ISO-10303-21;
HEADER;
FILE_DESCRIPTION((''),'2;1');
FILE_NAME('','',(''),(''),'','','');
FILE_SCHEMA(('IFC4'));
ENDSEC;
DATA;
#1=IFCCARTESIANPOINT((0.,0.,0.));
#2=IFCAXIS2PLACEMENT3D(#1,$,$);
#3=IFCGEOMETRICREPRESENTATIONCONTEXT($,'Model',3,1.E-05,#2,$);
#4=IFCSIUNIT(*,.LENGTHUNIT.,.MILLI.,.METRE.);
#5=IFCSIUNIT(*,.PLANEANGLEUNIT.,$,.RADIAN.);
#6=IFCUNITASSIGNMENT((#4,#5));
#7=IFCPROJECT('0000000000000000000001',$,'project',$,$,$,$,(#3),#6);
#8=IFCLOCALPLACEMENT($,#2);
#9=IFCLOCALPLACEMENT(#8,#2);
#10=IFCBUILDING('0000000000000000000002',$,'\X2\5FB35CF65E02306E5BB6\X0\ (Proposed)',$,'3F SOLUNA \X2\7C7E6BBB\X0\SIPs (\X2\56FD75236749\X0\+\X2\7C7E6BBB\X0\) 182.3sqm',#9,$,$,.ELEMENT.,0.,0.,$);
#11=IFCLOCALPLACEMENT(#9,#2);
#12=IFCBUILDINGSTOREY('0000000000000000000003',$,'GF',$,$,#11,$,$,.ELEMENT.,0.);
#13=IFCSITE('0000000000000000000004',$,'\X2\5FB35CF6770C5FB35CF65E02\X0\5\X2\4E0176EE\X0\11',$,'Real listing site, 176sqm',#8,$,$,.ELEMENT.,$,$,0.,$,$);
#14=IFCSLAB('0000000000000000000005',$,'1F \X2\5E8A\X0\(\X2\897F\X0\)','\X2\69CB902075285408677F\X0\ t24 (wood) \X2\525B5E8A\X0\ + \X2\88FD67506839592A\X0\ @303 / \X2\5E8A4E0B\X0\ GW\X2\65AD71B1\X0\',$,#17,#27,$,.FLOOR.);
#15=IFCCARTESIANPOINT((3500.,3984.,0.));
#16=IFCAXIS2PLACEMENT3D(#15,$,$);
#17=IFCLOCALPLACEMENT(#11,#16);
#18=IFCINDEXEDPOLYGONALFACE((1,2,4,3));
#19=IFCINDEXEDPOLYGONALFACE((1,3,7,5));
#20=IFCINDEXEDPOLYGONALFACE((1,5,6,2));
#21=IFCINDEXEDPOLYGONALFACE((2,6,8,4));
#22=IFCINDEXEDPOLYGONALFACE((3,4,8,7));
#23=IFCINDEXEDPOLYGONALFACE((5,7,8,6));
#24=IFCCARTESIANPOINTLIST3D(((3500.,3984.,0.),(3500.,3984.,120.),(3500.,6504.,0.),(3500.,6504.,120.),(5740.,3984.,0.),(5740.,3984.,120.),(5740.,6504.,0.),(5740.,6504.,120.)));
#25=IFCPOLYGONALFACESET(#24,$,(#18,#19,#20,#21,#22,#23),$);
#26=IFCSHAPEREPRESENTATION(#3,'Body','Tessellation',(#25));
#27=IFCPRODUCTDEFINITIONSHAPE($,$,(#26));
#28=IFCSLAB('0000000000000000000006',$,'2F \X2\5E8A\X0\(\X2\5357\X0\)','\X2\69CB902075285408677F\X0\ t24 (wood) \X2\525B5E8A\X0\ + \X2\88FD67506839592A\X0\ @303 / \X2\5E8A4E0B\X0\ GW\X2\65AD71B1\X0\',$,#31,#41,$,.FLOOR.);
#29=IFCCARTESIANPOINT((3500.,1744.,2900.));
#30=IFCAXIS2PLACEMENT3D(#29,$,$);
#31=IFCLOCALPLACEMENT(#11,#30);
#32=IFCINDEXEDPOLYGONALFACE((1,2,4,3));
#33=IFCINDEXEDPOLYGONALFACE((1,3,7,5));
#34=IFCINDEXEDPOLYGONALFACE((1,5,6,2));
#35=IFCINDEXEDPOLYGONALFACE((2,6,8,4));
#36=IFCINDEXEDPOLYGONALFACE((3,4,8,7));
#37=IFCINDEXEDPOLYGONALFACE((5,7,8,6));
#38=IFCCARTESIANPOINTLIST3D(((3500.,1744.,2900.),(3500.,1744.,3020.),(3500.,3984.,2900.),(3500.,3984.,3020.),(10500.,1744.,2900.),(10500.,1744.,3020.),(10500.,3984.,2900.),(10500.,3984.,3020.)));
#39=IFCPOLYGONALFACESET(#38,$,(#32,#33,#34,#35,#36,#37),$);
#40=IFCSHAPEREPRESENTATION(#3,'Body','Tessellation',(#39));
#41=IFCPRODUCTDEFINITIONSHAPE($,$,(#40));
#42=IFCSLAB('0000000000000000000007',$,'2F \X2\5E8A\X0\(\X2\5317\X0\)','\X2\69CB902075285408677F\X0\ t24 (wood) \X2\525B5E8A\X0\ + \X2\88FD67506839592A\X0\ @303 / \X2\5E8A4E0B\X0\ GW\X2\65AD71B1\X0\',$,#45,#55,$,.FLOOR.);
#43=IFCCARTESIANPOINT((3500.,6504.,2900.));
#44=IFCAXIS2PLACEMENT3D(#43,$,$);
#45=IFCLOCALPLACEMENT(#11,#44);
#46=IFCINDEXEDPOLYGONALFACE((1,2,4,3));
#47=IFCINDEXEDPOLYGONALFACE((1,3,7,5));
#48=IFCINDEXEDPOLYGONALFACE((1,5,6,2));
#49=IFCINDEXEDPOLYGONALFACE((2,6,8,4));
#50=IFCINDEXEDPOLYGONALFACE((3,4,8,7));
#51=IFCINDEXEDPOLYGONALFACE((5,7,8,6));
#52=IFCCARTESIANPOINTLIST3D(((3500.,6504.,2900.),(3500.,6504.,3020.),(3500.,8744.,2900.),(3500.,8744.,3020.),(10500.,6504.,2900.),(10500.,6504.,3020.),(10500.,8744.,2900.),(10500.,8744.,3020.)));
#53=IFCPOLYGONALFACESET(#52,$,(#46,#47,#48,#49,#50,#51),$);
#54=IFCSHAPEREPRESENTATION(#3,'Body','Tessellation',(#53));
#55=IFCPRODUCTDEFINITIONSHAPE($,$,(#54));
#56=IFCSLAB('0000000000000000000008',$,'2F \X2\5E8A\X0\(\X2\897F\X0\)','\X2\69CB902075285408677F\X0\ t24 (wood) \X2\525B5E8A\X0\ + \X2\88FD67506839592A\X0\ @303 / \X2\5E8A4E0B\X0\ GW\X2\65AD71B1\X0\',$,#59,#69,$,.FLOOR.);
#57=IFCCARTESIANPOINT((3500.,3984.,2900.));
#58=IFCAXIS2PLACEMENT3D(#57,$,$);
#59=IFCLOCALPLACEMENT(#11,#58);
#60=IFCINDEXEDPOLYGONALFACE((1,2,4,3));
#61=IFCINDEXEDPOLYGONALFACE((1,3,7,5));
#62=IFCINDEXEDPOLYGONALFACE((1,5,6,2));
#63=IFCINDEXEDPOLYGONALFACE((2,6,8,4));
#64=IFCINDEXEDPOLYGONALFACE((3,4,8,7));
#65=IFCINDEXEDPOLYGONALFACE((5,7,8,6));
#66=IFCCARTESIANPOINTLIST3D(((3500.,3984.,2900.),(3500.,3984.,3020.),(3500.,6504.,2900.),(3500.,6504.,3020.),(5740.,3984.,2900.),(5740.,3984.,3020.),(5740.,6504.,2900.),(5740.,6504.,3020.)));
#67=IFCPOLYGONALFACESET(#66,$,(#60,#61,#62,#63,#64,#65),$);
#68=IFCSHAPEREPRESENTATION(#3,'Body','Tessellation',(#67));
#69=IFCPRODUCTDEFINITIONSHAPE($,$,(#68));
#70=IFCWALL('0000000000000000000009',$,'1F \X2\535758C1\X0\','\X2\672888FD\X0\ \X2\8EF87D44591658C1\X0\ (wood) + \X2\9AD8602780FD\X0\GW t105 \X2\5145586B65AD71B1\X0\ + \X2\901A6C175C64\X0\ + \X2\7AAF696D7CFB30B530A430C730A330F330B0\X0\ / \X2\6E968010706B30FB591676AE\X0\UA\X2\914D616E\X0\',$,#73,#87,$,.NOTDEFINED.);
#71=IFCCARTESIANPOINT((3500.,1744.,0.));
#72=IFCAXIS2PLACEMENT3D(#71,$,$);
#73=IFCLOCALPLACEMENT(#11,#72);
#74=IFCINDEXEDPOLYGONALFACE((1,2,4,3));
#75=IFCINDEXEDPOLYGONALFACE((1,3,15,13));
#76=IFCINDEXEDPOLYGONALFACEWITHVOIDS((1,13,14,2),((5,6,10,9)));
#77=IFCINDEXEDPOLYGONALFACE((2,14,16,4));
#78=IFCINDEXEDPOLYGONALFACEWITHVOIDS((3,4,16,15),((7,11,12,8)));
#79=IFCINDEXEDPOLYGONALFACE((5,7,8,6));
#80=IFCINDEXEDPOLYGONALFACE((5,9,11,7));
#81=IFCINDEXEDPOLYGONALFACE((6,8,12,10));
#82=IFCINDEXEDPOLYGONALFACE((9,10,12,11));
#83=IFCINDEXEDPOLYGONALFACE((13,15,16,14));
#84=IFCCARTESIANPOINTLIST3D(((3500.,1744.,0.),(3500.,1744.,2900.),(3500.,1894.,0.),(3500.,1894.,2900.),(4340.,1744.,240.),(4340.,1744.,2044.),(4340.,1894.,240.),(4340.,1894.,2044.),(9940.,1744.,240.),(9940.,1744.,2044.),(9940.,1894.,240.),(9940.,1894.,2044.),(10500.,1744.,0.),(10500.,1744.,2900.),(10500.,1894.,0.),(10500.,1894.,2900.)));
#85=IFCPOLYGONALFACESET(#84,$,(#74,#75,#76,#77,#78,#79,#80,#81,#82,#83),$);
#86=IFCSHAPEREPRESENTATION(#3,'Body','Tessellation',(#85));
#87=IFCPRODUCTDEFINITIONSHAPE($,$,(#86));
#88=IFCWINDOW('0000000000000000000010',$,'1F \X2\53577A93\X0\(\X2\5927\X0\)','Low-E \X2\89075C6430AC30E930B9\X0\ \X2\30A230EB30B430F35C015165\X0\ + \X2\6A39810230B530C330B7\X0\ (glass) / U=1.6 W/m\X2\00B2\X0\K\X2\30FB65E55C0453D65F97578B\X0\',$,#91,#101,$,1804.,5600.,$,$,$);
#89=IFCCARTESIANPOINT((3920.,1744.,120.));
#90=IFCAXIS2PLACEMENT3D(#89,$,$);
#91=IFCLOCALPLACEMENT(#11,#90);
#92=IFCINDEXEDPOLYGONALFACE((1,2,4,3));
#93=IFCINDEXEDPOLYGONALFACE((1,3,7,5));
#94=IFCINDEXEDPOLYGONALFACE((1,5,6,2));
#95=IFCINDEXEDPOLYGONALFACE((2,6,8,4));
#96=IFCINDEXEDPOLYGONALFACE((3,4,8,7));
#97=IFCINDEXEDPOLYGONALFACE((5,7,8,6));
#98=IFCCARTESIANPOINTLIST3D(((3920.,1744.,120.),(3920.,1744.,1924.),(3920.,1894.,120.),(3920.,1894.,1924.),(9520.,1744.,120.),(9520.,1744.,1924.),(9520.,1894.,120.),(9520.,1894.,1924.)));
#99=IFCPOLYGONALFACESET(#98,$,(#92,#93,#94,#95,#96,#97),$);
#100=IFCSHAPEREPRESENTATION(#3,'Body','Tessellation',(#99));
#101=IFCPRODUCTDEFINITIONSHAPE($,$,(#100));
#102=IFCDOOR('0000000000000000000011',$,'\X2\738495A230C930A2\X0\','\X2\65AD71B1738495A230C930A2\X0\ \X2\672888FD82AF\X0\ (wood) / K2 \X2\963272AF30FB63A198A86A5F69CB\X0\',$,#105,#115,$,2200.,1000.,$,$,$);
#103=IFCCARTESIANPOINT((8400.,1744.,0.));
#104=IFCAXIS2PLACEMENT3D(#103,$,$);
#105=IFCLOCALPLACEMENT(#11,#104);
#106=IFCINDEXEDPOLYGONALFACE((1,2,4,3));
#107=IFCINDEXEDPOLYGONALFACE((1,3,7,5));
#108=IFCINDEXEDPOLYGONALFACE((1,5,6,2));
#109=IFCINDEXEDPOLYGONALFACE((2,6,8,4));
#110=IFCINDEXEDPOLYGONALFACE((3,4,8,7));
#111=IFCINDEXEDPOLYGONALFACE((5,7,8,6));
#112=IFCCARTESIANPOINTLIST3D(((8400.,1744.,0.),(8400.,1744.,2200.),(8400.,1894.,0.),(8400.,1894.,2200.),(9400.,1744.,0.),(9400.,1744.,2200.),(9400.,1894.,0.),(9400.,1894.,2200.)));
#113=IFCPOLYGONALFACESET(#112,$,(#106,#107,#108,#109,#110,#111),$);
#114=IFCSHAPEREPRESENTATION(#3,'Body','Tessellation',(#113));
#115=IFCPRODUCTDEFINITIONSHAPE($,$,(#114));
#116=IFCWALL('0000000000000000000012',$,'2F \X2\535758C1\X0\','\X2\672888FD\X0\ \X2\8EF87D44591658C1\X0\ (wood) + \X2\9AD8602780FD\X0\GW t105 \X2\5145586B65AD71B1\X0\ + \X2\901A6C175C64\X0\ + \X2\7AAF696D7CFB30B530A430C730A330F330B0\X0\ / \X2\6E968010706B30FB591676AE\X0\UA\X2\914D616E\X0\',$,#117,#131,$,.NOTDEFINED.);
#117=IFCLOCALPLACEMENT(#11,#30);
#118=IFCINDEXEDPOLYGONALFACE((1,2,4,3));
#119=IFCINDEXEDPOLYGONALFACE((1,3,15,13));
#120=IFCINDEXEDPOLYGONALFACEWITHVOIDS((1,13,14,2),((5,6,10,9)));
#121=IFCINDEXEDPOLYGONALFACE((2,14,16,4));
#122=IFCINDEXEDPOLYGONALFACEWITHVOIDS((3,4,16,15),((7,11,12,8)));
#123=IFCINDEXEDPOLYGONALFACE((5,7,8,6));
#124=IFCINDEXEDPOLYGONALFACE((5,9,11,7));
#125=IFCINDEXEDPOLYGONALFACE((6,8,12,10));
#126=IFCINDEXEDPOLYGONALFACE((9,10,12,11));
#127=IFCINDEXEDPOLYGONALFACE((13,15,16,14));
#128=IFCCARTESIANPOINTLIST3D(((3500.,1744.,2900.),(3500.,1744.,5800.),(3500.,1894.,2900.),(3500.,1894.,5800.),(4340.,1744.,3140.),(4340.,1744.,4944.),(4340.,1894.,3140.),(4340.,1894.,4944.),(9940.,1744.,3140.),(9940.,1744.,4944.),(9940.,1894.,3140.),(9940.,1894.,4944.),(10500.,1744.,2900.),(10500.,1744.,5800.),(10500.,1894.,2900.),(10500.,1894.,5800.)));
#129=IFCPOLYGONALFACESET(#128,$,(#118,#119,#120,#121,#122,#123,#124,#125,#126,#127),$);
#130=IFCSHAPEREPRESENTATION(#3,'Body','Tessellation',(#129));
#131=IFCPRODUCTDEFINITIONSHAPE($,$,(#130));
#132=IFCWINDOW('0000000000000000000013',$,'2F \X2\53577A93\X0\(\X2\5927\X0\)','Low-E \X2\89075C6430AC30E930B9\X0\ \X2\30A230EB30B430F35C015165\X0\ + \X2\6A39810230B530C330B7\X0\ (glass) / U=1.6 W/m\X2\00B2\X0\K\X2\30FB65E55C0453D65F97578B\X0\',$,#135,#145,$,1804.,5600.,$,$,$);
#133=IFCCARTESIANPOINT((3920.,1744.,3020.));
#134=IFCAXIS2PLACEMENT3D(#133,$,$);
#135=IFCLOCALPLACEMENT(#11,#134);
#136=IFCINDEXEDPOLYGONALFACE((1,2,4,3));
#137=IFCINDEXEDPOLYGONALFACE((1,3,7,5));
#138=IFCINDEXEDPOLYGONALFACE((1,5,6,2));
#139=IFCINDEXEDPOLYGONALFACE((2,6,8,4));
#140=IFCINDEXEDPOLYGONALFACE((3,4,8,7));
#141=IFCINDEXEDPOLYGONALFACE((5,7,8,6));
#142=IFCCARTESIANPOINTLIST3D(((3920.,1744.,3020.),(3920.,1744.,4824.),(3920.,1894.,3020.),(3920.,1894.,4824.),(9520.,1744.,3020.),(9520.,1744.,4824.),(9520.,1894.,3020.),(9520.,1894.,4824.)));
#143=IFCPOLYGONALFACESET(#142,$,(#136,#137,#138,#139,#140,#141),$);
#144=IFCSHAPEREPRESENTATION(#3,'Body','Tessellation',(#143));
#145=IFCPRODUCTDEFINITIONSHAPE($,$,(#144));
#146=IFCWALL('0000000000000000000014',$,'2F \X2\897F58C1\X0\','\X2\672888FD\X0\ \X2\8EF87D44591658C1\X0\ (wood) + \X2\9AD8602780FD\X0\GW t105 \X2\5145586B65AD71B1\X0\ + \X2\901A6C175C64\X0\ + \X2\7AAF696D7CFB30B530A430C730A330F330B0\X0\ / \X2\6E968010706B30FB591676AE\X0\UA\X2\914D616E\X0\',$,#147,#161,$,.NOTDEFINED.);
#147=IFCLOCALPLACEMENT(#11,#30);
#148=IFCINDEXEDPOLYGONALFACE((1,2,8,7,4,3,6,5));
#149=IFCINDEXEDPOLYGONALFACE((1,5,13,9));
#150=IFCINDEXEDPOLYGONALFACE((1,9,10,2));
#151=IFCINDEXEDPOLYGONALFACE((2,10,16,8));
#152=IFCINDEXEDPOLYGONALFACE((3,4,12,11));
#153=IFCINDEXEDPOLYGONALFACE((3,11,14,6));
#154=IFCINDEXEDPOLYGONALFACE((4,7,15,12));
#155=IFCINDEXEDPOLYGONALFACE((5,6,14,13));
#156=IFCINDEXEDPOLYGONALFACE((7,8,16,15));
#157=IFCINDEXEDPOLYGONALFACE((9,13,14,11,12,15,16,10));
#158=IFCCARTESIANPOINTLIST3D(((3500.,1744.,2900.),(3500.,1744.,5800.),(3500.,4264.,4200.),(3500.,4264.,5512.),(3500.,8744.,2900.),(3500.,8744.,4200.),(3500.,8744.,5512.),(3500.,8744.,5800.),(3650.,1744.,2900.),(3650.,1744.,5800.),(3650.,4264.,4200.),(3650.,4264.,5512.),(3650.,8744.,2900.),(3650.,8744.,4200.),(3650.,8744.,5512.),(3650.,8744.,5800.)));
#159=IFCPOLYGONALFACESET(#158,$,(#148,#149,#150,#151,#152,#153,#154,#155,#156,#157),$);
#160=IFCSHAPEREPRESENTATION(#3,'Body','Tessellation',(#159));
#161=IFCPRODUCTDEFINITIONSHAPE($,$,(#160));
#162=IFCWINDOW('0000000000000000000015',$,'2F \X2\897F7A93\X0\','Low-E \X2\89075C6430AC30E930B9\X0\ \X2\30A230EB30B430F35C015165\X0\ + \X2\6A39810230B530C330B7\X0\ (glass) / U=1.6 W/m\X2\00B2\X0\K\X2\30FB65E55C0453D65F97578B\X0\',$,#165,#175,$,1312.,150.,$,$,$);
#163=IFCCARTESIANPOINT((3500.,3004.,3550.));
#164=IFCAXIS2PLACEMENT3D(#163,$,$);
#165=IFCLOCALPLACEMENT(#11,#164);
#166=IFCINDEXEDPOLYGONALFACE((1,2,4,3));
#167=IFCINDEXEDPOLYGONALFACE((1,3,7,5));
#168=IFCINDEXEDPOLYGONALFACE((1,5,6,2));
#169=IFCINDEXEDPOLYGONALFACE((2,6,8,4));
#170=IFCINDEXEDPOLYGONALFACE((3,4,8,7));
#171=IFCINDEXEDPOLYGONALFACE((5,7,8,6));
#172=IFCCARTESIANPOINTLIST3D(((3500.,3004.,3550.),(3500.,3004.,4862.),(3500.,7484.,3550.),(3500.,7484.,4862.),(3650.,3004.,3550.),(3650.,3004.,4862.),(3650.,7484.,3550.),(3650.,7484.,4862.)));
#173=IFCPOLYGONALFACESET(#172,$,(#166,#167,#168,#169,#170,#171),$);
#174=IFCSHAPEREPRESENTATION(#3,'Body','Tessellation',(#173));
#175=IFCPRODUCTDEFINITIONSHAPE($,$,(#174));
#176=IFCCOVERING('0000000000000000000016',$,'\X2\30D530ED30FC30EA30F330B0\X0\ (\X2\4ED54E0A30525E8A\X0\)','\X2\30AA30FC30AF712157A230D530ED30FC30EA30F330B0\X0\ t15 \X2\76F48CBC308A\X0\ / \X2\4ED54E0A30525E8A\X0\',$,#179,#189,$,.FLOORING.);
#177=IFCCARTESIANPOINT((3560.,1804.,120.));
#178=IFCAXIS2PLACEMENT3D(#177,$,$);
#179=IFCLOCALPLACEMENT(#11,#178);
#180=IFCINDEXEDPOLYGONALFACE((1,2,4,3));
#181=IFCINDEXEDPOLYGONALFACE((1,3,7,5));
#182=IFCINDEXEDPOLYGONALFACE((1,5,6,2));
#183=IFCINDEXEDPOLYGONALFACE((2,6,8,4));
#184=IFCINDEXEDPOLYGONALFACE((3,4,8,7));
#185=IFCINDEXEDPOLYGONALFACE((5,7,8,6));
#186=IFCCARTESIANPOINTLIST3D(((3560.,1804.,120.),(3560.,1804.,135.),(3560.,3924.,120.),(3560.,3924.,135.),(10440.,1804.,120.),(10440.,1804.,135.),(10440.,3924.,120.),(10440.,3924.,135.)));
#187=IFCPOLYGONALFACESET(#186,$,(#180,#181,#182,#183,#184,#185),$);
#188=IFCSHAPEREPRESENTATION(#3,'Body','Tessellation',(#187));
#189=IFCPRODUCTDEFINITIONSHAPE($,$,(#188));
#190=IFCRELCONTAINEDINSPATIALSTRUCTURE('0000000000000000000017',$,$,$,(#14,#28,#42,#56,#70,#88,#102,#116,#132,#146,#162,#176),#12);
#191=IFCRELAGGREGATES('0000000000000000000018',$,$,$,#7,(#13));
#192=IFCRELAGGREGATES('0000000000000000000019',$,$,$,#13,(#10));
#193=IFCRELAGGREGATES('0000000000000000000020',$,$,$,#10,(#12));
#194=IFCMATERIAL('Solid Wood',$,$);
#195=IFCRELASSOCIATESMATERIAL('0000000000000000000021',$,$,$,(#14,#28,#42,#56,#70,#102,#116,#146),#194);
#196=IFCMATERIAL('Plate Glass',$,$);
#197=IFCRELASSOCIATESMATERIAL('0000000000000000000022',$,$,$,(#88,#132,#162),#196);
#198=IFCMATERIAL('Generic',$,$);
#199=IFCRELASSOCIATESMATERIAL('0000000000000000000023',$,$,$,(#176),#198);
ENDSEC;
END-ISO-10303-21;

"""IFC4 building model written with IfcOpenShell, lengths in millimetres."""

from ifc_helpers import new_model, si_unit, frame, frame_2d, origin, place, context, project, spatial, rectangle, extrude, material, element, fill, save


model = new_model("IFC4")

# Units and contexts
model_context = context("Model", 3, precision=1e-05, world=origin())
ifc_project = project(units=[si_unit("LENGTHUNIT", "METRE", prefix="MILLI"), si_unit("PLANEANGLEUNIT", "RADIAN")], contexts=[model_context])

# Site, building, storey
site_placement = place(None, origin())
site = spatial("IfcSite", under=ifc_project, at=site_placement, Name="徳島県徳島市5丁目11", ObjectType="Real listing site, 176sqm", CompositionType="ELEMENT", RefElevation=0.0)
building_placement = place(site_placement, origin())
building = spatial("IfcBuilding", under=site, at=building_placement, Name="徳島市の家 (Proposed)", ObjectType="3F SOLUNA 籾殻SIPs (国産杉+籾殻) 182.3sqm", CompositionType="ELEMENT", ElevationOfRefHeight=0.0, ElevationOfTerrain=0.0)
storey_placement = place(building_placement, origin())
storey = spatial("IfcBuildingStorey", under=building, at=storey_placement, Name="GF", CompositionType="ELEMENT", Elevation=0.0)

# Slabs
ifc_material_1 = material(Name="Solid Wood")
slab_1_placement = place(storey_placement, frame((3500.0, 3984.0, 0.0)))
element("IfcSlab", 1, at=slab_1_placement, inside=storey, material=ifc_material_1, Name="1F 床(西)", Description="構造用合板 t24 (wood) 剛床 + 製材根太 @303 / 床下 GW断熱", PredefinedType="FLOOR", context=model_context, shape_type="SweptSolid", body=[
    extrude(rectangle(XDim=2240.0, YDim=2520.0, at=frame_2d((1120.0, 1260.0))), frame((3500.0, 3984.0, 0.0)), (0.0, 0.0, 1.0), 120.0),
])
slab_2_placement = place(storey_placement, frame((3500.0, 1744.0, 2900.0)))
element("IfcSlab", 2, at=slab_2_placement, inside=storey, material=ifc_material_1, Name="2F 床(南)", Description="構造用合板 t24 (wood) 剛床 + 製材根太 @303 / 床下 GW断熱", PredefinedType="FLOOR", context=model_context, shape_type="SweptSolid", body=[
    extrude(rectangle(XDim=7000.0, YDim=2240.0, at=frame_2d((3500.0, 1120.0))), frame((3500.0, 1744.0, 2900.0)), (0.0, 0.0, 1.0), 120.0),
])
slab_3_placement = place(storey_placement, frame((3500.0, 6504.0, 2900.0)))
element("IfcSlab", 3, at=slab_3_placement, inside=storey, material=ifc_material_1, Name="2F 床(北)", Description="構造用合板 t24 (wood) 剛床 + 製材根太 @303 / 床下 GW断熱", PredefinedType="FLOOR", context=model_context, shape_type="SweptSolid", body=[
    extrude(rectangle(XDim=7000.0, YDim=2240.0, at=frame_2d((3500.0, 1120.0))), frame((3500.0, 6504.0, 2900.0)), (0.0, 0.0, 1.0), 120.0),
])
slab_4_placement = place(storey_placement, frame((3500.0, 3984.0, 2900.0)))
element("IfcSlab", 4, at=slab_4_placement, inside=storey, material=ifc_material_1, Name="2F 床(西)", Description="構造用合板 t24 (wood) 剛床 + 製材根太 @303 / 床下 GW断熱", PredefinedType="FLOOR", context=model_context, shape_type="SweptSolid", body=[
    extrude(rectangle(XDim=2240.0, YDim=2520.0, at=frame_2d((1120.0, 1260.0))), frame((3500.0, 3984.0, 2900.0)), (0.0, 0.0, 1.0), 120.0),
])

# Wall, openings, window, door
wall_1_placement = place(storey_placement, frame((3500.0, 1744.0, 0.0)))
wall_1 = element("IfcWall", 5, at=wall_1_placement, inside=storey, material=ifc_material_1, Name="1F 南壁", Description="木製 軸組外壁 (wood) + 高性能GW t105 充填断熱 + 通気層 + 窯業系サイディング / 準耐火・外皮UA配慮", PredefinedType="NOTDEFINED", context=model_context, shape_type="SweptSolid", body=[
    extrude(rectangle(XDim=7000.0, YDim=150.0, at=frame_2d((3500.0, 75.0))), frame((3500.0, 1744.0, 0.0)), (0.0, 0.0, 1.0), 2900.0),
])
opening_1_placement = place(storey_placement, frame((3920.0, 1744.0, 120.0)))
opening_1 = element("IfcOpeningElement", 6, at=opening_1_placement, cuts=wall_1, PredefinedType="NOTDEFINED", context=model_context, shape_type="SweptSolid", body=[
    extrude(rectangle(XDim=5600.0, YDim=150.0, at=frame_2d((2800.0, 75.0))), frame((3920.0, 1744.0, 120.0)), (0.0, 0.0, 1.0), 1804.0),
])
opening_2_placement = place(storey_placement, frame((8400.0, 1744.0, 0.0)))
opening_2 = element("IfcOpeningElement", 7, at=opening_2_placement, cuts=wall_1, PredefinedType="NOTDEFINED", context=model_context, shape_type="SweptSolid", body=[
    extrude(rectangle(XDim=1000.0, YDim=150.0, at=frame_2d((500.0, 75.0))), frame((8400.0, 1744.0, 0.0)), (0.0, 0.0, 1.0), 2200.0),
])
ifc_material_2 = material(Name="Plate Glass")
window_1_placement = place(storey_placement, frame((3920.0, 1744.0, 120.0)))
window_1 = element("IfcWindow", 8, at=window_1_placement, inside=storey, material=ifc_material_2, Name="1F 南窓(大)", Description="Low-E 複層ガラス アルゴン封入 + 樹脂サッシ (glass) / U=1.6 W/m²K・日射取得型", OverallHeight=1804.0, OverallWidth=5600.0, context=model_context, shape_type="SweptSolid", body=[
    extrude(rectangle(XDim=5600.0, YDim=150.0, at=frame_2d((2800.0, 75.0))), frame((3920.0, 1744.0, 120.0)), (0.0, 0.0, 1.0), 1804.0),
])
fill(opening_1, window_1)
door_placement = place(storey_placement, frame((8400.0, 1744.0, 0.0)))
door = element("IfcDoor", 9, at=door_placement, inside=storey, material=ifc_material_1, Name="玄関ドア", Description="断熱玄関ドア 木製芯 (wood) / K2 防犯・採風機構", OverallHeight=2200.0, OverallWidth=1000.0, context=model_context, shape_type="SweptSolid", body=[
    extrude(rectangle(XDim=1000.0, YDim=150.0, at=frame_2d((500.0, 75.0))), frame((8400.0, 1744.0, 0.0)), (0.0, 0.0, 1.0), 2200.0),
])
fill(opening_2, door)

# Wall, opening, window
wall_2_placement = place(storey_placement, frame((3500.0, 1744.0, 2900.0)))
wall_2 = element("IfcWall", 10, at=wall_2_placement, inside=storey, material=ifc_material_1, Name="2F 南壁", Description="木製 軸組外壁 (wood) + 高性能GW t105 充填断熱 + 通気層 + 窯業系サイディング / 準耐火・外皮UA配慮", PredefinedType="NOTDEFINED", context=model_context, shape_type="SweptSolid", body=[
    extrude(rectangle(XDim=7000.0, YDim=150.0, at=frame_2d((3500.0, 75.0))), frame((3500.0, 1744.0, 2900.0)), (0.0, 0.0, 1.0), 2900.0),
])
opening_3_placement = place(storey_placement, frame((3920.0, 1744.0, 3020.0)))
opening_3 = element("IfcOpeningElement", 11, at=opening_3_placement, cuts=wall_2, PredefinedType="NOTDEFINED", context=model_context, shape_type="SweptSolid", body=[
    extrude(rectangle(XDim=5600.0, YDim=150.0, at=frame_2d((2800.0, 75.0))), frame((3920.0, 1744.0, 3020.0)), (0.0, 0.0, 1.0), 1804.0),
])
window_2_placement = place(storey_placement, frame((3920.0, 1744.0, 3020.0)))
window_2 = element("IfcWindow", 12, at=window_2_placement, inside=storey, material=ifc_material_2, Name="2F 南窓(大)", Description="Low-E 複層ガラス アルゴン封入 + 樹脂サッシ (glass) / U=1.6 W/m²K・日射取得型", OverallHeight=1804.0, OverallWidth=5600.0, context=model_context, shape_type="SweptSolid", body=[
    extrude(rectangle(XDim=5600.0, YDim=150.0, at=frame_2d((2800.0, 75.0))), frame((3920.0, 1744.0, 3020.0)), (0.0, 0.0, 1.0), 1804.0),
])
fill(opening_3, window_2)

# Wall, opening, window
wall_3_placement = place(storey_placement, frame((3500.0, 1744.0, 2900.0)))
wall_3 = element("IfcWall", 13, at=wall_3_placement, inside=storey, material=ifc_material_1, Name="2F 西壁", Description="木製 軸組外壁 (wood) + 高性能GW t105 充填断熱 + 通気層 + 窯業系サイディング / 準耐火・外皮UA配慮", PredefinedType="NOTDEFINED", context=model_context, shape_type="SweptSolid", body=[
    extrude(rectangle(XDim=150.0, YDim=7000.0, at=frame_2d((75.0, 3500.0))), frame((3500.0, 1744.0, 2900.0)), (0.0, 0.0, 1.0), 2900.0),
])
opening_4_placement = place(storey_placement, frame((3500.0, 3004.0, 3550.0)))
opening_4 = element("IfcOpeningElement", 14, at=opening_4_placement, cuts=wall_3, PredefinedType="NOTDEFINED", context=model_context, shape_type="SweptSolid", body=[
    extrude(rectangle(XDim=150.0, YDim=4480.0, at=frame_2d((75.0, 2240.0))), frame((3500.0, 3004.0, 3550.0)), (0.0, 0.0, 1.0), 1312.0),
])
window_3_placement = place(storey_placement, frame((3500.0, 3004.0, 3550.0)))
window_3 = element("IfcWindow", 15, at=window_3_placement, inside=storey, material=ifc_material_2, Name="2F 西窓", Description="Low-E 複層ガラス アルゴン封入 + 樹脂サッシ (glass) / U=1.6 W/m²K・日射取得型", OverallHeight=1312.0, OverallWidth=150.0, context=model_context, shape_type="SweptSolid", body=[
    extrude(rectangle(XDim=150.0, YDim=4480.0, at=frame_2d((75.0, 2240.0))), frame((3500.0, 3004.0, 3550.0)), (0.0, 0.0, 1.0), 1312.0),
])
fill(opening_4, window_3)

# Covering
ifc_material_3 = material(Name="Generic")
covering_1_placement = place(storey_placement, frame((3560.0, 1804.0, 120.0)))
element("IfcCovering", 16, at=covering_1_placement, inside=storey, material=ifc_material_3, Name="フローリング (仕上げ床)", Description="オーク無垢フローリング t15 直貼り / 仕上げ床", PredefinedType="FLOORING", context=model_context, shape_type="SweptSolid", body=[
    extrude(rectangle(XDim=6880.0, YDim=2120.0, at=frame_2d((3440.0, 1060.0))), frame((3560.0, 1804.0, 120.0)), (0.0, 0.0, 1.0), 15.0),
])

save(model, "model.ifc")
